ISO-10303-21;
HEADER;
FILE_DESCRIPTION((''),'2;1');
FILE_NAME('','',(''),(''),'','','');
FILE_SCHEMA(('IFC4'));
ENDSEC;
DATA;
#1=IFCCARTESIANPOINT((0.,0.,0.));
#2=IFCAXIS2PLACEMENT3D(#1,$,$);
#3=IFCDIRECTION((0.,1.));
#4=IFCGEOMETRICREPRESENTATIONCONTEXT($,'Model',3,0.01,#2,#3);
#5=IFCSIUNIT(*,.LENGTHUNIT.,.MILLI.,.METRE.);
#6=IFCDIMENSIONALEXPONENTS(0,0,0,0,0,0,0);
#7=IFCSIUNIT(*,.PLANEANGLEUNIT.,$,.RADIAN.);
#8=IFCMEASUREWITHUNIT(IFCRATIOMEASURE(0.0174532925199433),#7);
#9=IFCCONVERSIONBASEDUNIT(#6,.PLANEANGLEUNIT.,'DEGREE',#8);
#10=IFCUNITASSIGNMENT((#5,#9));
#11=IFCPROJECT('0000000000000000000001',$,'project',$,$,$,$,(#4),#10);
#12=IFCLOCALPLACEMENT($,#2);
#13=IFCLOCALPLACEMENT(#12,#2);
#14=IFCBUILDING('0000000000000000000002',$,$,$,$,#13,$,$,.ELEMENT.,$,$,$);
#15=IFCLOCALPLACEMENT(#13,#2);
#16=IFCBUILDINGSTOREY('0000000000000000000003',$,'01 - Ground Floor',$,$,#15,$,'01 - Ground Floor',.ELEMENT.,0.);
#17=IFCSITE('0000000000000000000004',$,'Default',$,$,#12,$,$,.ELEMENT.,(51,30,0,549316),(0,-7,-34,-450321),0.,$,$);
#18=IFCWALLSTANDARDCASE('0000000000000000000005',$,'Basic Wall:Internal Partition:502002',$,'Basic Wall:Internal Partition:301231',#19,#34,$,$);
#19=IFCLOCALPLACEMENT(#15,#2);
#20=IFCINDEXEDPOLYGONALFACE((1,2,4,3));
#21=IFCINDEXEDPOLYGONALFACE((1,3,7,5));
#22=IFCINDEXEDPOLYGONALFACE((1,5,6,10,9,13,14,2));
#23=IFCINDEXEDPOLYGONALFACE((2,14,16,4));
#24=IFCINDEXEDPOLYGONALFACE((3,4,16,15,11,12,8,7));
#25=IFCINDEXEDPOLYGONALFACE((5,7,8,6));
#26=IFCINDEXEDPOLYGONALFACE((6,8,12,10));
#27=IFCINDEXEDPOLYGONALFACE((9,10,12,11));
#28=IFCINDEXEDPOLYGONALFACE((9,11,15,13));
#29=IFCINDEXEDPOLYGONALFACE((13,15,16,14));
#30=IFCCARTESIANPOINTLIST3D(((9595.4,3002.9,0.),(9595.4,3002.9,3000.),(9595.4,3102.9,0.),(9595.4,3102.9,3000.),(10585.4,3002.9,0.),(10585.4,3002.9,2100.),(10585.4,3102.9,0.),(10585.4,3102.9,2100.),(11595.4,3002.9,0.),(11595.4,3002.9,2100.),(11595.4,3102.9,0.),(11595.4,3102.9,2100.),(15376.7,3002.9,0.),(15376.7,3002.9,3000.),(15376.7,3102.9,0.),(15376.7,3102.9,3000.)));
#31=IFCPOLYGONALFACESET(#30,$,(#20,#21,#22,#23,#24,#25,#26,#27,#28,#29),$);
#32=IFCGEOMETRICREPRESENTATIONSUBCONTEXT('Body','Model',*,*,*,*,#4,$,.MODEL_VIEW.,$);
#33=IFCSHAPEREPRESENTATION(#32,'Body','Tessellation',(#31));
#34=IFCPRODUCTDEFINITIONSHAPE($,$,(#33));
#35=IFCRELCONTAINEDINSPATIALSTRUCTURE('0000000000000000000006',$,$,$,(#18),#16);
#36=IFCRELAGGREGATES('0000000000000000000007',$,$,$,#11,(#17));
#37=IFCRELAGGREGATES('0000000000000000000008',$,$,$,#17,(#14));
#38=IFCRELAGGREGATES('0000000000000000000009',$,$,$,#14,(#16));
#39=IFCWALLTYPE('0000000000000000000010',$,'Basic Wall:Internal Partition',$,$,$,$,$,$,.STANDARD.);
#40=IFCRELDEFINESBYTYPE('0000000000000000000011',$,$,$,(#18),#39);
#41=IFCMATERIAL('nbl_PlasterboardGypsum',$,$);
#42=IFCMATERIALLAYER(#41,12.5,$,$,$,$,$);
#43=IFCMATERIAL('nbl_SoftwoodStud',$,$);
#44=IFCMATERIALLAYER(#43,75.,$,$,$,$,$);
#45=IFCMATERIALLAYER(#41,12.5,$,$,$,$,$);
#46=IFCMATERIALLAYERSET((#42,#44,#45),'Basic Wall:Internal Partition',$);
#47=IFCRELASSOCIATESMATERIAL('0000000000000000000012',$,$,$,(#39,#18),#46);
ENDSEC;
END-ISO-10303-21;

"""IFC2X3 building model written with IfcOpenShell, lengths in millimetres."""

from ifc_helpers import new_model, entity, si_unit, converted_unit, direction, frame, frame_2d, origin, place, context, subcontext, project, spatial, rectangle, extrude, material, layer, layer_set, layer_usage, type_object, element, save


model = new_model("IFC2X3")

# Units and contexts
model_context = context("Model", 3, precision=0.01, world=origin(), true_north=direction((0.0, 1.0)))
body_context = subcontext(model_context, "Body", "Model", "MODEL_VIEW")
ifc_project = project(units=[si_unit("LENGTHUNIT", "METRE", prefix="MILLI"), converted_unit("PLANEANGLEUNIT", "DEGREE", entity("IfcRatioMeasure", 0.0174532925199433), si_unit("PLANEANGLEUNIT", "RADIAN"), dimensions=[0, 0, 0, 0, 0, 0, 0])], contexts=[model_context])

# Site, building, storey
site_placement = place(None, origin())
site = spatial("IfcSite", under=ifc_project, at=site_placement, Name="Default", CompositionType="ELEMENT", RefLatitude=(51, 30, 0, 549316), RefLongitude=(0, -7, -34, -450321), RefElevation=0.0)
building_placement = place(site_placement, origin())
building = spatial("IfcBuilding", under=site, at=building_placement, CompositionType="ELEMENT")
storey_placement = place(building_placement, origin())
storey = spatial("IfcBuildingStorey", under=building, at=storey_placement, Name="01 - Ground Floor", LongName="01 - Ground Floor", CompositionType="ELEMENT", Elevation=0.0)

# Shared definitions
ifc_material_1 = material(Name="nbl_PlasterboardGypsum")

# Wall, opening
ifc_layer_1 = layer(ifc_material_1, 12.5)
ifc_material_2 = material(Name="nbl_SoftwoodStud")
ifc_layer_2 = layer(ifc_material_2, 75.0)
ifc_layer_3 = layer(ifc_material_1, 12.5)
ifc_layer_set_1 = layer_set([ifc_layer_1, ifc_layer_2, ifc_layer_3], Name="Basic Wall:Internal Partition")
wall_type_1 = type_object("IfcWallType", Name="Basic Wall:Internal Partition", PredefinedType="STANDARD", material=ifc_layer_set_1)
ifc_layer_usage_1 = layer_usage(ifc_layer_set_1, "AXIS2", "NEGATIVE", 50.0)
wall_1_placement = place(storey_placement, frame((15376.7, 3052.9, 0.0), z_axis=(0.0, 0.0, 1.0), x_axis=(-1.0, 0.0, 0.0)))
wall_1 = element("IfcWallStandardCase", 1, at=wall_1_placement, inside=storey, type_object=wall_type_1, material=ifc_layer_usage_1, Name="Basic Wall:Internal Partition:502002", ObjectType="Basic Wall:Internal Partition:301231", context=body_context, shape_type="SweptSolid", body=[
    extrude(rectangle(XDim=5781.2, YDim=100.0, at=frame_2d((2890.6, 0.0), x_axis=(-1.0, 0.0))), origin(), (0.0, 0.0, 1.0), 3000.0),
])
opening_1_placement = place(wall_1_placement, frame((3781.3, -50.0, 0.0)))
element("IfcOpeningElement", 2, at=opening_1_placement, cuts=wall_1, ObjectType="Opening", context=body_context, shape_type="SweptSolid", body=[
    extrude(rectangle(XDim=2100.0, YDim=1010.0, at=frame_2d((1050.0, 505.0), x_axis=(-1.0, 0.0))), frame((0.0, 0.0, 0.0), z_axis=(0.0, 1.0, 0.0), x_axis=(0.0, 0.0, 1.0)), (0.0, 0.0, 1.0), 100.0),
])

save(model, "model.ifc")
